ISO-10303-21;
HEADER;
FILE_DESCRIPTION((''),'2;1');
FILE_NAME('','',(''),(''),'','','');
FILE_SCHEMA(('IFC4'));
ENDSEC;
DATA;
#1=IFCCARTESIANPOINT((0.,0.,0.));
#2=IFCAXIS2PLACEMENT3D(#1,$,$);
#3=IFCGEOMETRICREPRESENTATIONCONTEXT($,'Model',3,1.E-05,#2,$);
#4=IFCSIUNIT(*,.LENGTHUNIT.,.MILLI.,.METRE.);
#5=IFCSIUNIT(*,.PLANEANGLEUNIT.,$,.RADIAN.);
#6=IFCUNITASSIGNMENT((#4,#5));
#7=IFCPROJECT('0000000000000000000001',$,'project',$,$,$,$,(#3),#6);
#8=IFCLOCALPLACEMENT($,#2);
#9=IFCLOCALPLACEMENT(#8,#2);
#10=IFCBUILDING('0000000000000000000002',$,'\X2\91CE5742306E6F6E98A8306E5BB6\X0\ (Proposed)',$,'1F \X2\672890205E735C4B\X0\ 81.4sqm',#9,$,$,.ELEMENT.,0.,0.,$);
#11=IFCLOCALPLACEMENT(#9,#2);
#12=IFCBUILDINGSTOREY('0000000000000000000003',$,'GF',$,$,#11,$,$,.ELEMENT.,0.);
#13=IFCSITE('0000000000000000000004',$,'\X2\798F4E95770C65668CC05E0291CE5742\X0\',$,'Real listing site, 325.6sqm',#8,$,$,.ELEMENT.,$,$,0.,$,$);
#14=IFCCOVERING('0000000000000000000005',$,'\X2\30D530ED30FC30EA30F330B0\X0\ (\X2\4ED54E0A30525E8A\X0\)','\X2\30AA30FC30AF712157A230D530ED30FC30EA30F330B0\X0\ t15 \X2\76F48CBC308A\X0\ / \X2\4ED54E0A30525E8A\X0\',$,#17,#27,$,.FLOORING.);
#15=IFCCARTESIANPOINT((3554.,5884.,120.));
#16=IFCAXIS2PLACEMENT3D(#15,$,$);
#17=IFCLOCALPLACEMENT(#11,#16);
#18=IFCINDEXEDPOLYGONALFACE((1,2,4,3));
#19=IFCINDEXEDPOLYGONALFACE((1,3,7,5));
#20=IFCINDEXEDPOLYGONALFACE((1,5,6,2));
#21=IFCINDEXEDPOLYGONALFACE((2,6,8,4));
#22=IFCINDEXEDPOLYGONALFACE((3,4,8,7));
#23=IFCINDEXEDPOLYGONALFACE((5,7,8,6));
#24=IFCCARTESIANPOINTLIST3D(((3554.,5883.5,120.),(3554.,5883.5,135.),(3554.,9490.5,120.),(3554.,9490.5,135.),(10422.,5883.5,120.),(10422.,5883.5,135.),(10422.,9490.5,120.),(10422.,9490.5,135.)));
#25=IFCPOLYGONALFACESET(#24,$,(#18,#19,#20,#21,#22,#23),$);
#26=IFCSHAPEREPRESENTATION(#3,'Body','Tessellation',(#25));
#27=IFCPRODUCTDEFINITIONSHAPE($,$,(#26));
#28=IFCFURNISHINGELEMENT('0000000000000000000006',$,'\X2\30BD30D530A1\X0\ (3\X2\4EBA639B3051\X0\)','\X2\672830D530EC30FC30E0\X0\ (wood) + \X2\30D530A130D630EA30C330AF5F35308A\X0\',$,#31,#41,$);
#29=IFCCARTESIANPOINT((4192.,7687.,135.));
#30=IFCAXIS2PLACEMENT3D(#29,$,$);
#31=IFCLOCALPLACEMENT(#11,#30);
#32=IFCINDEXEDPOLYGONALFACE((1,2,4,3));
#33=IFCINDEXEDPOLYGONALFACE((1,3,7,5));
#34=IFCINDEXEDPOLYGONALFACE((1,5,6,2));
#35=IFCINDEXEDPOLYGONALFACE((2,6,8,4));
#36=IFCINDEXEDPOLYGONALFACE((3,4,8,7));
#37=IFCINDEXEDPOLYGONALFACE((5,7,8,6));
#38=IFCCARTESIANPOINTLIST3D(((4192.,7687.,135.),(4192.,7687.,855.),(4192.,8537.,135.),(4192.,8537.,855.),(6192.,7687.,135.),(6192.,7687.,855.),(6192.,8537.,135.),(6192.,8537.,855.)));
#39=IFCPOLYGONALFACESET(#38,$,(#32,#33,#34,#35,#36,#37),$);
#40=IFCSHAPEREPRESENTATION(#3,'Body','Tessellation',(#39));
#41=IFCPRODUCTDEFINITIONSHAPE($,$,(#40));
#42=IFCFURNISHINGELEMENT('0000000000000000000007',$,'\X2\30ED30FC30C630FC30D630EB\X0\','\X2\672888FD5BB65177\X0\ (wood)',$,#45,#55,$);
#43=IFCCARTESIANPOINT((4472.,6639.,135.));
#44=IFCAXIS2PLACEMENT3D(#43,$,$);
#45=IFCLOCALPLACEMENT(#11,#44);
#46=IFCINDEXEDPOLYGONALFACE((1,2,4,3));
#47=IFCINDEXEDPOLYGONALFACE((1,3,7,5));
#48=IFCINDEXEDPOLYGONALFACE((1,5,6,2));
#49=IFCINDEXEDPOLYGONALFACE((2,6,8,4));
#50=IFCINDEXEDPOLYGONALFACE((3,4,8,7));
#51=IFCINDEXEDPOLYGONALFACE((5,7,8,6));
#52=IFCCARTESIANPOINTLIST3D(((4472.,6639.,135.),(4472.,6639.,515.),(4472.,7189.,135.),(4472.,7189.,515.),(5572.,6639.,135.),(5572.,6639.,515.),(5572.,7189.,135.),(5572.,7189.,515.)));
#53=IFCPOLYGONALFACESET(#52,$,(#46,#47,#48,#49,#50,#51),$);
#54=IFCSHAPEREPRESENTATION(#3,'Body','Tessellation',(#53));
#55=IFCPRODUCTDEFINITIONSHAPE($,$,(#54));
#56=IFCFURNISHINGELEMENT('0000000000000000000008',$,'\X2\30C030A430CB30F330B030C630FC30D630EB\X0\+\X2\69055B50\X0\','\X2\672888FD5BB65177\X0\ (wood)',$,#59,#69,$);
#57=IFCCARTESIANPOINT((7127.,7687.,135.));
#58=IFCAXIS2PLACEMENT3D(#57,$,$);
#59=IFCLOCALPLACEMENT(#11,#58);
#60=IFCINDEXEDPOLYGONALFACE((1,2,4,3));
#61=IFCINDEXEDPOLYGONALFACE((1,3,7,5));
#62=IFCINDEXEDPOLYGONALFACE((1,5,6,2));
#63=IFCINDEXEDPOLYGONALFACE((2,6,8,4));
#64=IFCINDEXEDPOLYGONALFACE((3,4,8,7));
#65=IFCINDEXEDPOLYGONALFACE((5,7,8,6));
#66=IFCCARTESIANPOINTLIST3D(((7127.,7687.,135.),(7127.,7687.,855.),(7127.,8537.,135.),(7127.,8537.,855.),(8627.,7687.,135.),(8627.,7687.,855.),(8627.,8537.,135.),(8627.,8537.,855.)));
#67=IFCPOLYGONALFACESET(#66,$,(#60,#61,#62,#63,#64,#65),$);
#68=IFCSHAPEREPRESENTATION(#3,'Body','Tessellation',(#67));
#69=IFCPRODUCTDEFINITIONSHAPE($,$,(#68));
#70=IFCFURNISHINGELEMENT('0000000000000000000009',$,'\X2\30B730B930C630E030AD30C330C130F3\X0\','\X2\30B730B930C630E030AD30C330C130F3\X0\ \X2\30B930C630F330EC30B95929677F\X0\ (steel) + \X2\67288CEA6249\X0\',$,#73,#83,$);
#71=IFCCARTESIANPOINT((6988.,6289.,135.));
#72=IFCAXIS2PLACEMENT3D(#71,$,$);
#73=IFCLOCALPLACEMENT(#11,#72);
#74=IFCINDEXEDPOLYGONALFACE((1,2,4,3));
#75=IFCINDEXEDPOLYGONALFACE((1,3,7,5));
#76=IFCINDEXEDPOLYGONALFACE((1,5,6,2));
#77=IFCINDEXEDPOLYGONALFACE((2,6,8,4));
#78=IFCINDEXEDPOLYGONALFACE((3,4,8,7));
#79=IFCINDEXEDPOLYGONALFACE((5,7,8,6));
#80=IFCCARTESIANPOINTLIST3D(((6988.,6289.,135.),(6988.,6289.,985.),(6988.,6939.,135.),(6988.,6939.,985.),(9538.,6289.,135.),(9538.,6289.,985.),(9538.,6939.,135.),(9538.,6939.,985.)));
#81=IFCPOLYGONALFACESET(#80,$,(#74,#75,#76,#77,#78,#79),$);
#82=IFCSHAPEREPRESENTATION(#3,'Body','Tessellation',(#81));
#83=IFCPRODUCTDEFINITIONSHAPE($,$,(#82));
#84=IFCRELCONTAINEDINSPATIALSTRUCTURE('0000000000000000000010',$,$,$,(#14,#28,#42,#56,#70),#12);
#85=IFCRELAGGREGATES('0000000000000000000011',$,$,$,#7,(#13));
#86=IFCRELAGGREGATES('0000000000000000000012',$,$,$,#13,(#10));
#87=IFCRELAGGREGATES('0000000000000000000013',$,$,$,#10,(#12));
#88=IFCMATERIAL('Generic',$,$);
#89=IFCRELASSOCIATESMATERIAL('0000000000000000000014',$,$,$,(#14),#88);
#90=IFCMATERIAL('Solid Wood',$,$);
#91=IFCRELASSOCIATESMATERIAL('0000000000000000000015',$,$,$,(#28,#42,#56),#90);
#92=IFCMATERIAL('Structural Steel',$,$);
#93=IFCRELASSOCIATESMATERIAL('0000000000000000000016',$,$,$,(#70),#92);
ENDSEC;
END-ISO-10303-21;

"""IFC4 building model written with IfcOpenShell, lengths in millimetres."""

from ifc_helpers import new_model, si_unit, frame, frame_2d, origin, place, context, project, spatial, rectangle, extrude, material, element, save


model = new_model("IFC4")

# Units and contexts
model_context = context("Model", 3, precision=1e-05, world=origin())
ifc_project = project(units=[si_unit("LENGTHUNIT", "METRE", prefix="MILLI"), si_unit("PLANEANGLEUNIT", "RADIAN")], contexts=[model_context])

# Site, building, storey
site_placement = place(None, origin())
site = spatial("IfcSite", under=ifc_project, at=site_placement, Name="福井県敦賀市野坂", ObjectType="Real listing site, 325.6sqm", CompositionType="ELEMENT", RefElevation=0.0)
building_placement = place(site_placement, origin())
building = spatial("IfcBuilding", under=site, at=building_placement, Name="野坂の潮風の家 (Proposed)", ObjectType="1F 木造平屋 81.4sqm", CompositionType="ELEMENT", ElevationOfRefHeight=0.0, ElevationOfTerrain=0.0)
storey_placement = place(building_placement, origin())
storey = spatial("IfcBuildingStorey", under=building, at=storey_placement, Name="GF", CompositionType="ELEMENT", Elevation=0.0)

# Shared definitions
ifc_material_1 = material(Name="Solid Wood")

# Shared definitions
ifc_material_2 = material(Name="Structural Steel")

# Covering
ifc_material_3 = material(Name="Generic")
covering_placement = place(storey_placement, frame((3554.0, 5884.0, 120.0)))
element("IfcCovering", 1, at=covering_placement, inside=storey, material=ifc_material_3, Name="フローリング (仕上げ床)", Description="オーク無垢フローリング t15 直貼り / 仕上げ床", PredefinedType="FLOORING", context=model_context, shape_type="SweptSolid", body=[
    extrude(rectangle(XDim=6868.0, YDim=3607.0, at=frame_2d((3434.0, 1803.0))), frame((3554.0, 5884.0, 120.0)), (0.0, 0.0, 1.0), 15.0),
])

# Furnishing elements
furnishing_1_placement = place(storey_placement, frame((4192.0, 7687.0, 135.0)))
element("IfcFurnishingElement", 2, at=furnishing_1_placement, inside=storey, material=ifc_material_1, Name="ソファ (3人掛け)", Description="木フレーム (wood) + ファブリック張り", context=model_context, shape_type="SweptSolid", body=[
    extrude(rectangle(XDim=2000.0, YDim=850.0, at=frame_2d((1000.0, 425.0))), frame((4192.0, 7687.0, 135.0)), (0.0, 0.0, 1.0), 720.0),
])
furnishing_2_placement = place(storey_placement, frame((4472.0, 6639.0, 135.0)))
element("IfcFurnishingElement", 3, at=furnishing_2_placement, inside=storey, material=ifc_material_1, Name="ローテーブル", Description="木製家具 (wood)", context=model_context, shape_type="SweptSolid", body=[
    extrude(rectangle(XDim=1100.0, YDim=550.0, at=frame_2d((550.0, 275.0))), frame((4472.0, 6639.0, 135.0)), (0.0, 0.0, 1.0), 380.0),
])
furnishing_3_placement = place(storey_placement, frame((7127.0, 7687.0, 135.0)))
element("IfcFurnishingElement", 4, at=furnishing_3_placement, inside=storey, material=ifc_material_1, Name="ダイニングテーブル+椅子", Description="木製家具 (wood)", context=model_context, shape_type="SweptSolid", body=[
    extrude(rectangle(XDim=1500.0, YDim=850.0, at=frame_2d((750.0, 425.0))), frame((7127.0, 7687.0, 135.0)), (0.0, 0.0, 1.0), 720.0),
])
furnishing_4_placement = place(storey_placement, frame((6988.0, 6289.0, 135.0)))
element("IfcFurnishingElement", 5, at=furnishing_4_placement, inside=storey, material=ifc_material_2, Name="システムキッチン", Description="システムキッチン ステンレス天板 (steel) + 木質扉", context=model_context, shape_type="SweptSolid", body=[
    extrude(rectangle(XDim=2550.0, YDim=650.0, at=frame_2d((1275.0, 325.0))), frame((6988.0, 6289.0, 135.0)), (0.0, 0.0, 1.0), 850.0),
])

save(model, "model.ifc")
